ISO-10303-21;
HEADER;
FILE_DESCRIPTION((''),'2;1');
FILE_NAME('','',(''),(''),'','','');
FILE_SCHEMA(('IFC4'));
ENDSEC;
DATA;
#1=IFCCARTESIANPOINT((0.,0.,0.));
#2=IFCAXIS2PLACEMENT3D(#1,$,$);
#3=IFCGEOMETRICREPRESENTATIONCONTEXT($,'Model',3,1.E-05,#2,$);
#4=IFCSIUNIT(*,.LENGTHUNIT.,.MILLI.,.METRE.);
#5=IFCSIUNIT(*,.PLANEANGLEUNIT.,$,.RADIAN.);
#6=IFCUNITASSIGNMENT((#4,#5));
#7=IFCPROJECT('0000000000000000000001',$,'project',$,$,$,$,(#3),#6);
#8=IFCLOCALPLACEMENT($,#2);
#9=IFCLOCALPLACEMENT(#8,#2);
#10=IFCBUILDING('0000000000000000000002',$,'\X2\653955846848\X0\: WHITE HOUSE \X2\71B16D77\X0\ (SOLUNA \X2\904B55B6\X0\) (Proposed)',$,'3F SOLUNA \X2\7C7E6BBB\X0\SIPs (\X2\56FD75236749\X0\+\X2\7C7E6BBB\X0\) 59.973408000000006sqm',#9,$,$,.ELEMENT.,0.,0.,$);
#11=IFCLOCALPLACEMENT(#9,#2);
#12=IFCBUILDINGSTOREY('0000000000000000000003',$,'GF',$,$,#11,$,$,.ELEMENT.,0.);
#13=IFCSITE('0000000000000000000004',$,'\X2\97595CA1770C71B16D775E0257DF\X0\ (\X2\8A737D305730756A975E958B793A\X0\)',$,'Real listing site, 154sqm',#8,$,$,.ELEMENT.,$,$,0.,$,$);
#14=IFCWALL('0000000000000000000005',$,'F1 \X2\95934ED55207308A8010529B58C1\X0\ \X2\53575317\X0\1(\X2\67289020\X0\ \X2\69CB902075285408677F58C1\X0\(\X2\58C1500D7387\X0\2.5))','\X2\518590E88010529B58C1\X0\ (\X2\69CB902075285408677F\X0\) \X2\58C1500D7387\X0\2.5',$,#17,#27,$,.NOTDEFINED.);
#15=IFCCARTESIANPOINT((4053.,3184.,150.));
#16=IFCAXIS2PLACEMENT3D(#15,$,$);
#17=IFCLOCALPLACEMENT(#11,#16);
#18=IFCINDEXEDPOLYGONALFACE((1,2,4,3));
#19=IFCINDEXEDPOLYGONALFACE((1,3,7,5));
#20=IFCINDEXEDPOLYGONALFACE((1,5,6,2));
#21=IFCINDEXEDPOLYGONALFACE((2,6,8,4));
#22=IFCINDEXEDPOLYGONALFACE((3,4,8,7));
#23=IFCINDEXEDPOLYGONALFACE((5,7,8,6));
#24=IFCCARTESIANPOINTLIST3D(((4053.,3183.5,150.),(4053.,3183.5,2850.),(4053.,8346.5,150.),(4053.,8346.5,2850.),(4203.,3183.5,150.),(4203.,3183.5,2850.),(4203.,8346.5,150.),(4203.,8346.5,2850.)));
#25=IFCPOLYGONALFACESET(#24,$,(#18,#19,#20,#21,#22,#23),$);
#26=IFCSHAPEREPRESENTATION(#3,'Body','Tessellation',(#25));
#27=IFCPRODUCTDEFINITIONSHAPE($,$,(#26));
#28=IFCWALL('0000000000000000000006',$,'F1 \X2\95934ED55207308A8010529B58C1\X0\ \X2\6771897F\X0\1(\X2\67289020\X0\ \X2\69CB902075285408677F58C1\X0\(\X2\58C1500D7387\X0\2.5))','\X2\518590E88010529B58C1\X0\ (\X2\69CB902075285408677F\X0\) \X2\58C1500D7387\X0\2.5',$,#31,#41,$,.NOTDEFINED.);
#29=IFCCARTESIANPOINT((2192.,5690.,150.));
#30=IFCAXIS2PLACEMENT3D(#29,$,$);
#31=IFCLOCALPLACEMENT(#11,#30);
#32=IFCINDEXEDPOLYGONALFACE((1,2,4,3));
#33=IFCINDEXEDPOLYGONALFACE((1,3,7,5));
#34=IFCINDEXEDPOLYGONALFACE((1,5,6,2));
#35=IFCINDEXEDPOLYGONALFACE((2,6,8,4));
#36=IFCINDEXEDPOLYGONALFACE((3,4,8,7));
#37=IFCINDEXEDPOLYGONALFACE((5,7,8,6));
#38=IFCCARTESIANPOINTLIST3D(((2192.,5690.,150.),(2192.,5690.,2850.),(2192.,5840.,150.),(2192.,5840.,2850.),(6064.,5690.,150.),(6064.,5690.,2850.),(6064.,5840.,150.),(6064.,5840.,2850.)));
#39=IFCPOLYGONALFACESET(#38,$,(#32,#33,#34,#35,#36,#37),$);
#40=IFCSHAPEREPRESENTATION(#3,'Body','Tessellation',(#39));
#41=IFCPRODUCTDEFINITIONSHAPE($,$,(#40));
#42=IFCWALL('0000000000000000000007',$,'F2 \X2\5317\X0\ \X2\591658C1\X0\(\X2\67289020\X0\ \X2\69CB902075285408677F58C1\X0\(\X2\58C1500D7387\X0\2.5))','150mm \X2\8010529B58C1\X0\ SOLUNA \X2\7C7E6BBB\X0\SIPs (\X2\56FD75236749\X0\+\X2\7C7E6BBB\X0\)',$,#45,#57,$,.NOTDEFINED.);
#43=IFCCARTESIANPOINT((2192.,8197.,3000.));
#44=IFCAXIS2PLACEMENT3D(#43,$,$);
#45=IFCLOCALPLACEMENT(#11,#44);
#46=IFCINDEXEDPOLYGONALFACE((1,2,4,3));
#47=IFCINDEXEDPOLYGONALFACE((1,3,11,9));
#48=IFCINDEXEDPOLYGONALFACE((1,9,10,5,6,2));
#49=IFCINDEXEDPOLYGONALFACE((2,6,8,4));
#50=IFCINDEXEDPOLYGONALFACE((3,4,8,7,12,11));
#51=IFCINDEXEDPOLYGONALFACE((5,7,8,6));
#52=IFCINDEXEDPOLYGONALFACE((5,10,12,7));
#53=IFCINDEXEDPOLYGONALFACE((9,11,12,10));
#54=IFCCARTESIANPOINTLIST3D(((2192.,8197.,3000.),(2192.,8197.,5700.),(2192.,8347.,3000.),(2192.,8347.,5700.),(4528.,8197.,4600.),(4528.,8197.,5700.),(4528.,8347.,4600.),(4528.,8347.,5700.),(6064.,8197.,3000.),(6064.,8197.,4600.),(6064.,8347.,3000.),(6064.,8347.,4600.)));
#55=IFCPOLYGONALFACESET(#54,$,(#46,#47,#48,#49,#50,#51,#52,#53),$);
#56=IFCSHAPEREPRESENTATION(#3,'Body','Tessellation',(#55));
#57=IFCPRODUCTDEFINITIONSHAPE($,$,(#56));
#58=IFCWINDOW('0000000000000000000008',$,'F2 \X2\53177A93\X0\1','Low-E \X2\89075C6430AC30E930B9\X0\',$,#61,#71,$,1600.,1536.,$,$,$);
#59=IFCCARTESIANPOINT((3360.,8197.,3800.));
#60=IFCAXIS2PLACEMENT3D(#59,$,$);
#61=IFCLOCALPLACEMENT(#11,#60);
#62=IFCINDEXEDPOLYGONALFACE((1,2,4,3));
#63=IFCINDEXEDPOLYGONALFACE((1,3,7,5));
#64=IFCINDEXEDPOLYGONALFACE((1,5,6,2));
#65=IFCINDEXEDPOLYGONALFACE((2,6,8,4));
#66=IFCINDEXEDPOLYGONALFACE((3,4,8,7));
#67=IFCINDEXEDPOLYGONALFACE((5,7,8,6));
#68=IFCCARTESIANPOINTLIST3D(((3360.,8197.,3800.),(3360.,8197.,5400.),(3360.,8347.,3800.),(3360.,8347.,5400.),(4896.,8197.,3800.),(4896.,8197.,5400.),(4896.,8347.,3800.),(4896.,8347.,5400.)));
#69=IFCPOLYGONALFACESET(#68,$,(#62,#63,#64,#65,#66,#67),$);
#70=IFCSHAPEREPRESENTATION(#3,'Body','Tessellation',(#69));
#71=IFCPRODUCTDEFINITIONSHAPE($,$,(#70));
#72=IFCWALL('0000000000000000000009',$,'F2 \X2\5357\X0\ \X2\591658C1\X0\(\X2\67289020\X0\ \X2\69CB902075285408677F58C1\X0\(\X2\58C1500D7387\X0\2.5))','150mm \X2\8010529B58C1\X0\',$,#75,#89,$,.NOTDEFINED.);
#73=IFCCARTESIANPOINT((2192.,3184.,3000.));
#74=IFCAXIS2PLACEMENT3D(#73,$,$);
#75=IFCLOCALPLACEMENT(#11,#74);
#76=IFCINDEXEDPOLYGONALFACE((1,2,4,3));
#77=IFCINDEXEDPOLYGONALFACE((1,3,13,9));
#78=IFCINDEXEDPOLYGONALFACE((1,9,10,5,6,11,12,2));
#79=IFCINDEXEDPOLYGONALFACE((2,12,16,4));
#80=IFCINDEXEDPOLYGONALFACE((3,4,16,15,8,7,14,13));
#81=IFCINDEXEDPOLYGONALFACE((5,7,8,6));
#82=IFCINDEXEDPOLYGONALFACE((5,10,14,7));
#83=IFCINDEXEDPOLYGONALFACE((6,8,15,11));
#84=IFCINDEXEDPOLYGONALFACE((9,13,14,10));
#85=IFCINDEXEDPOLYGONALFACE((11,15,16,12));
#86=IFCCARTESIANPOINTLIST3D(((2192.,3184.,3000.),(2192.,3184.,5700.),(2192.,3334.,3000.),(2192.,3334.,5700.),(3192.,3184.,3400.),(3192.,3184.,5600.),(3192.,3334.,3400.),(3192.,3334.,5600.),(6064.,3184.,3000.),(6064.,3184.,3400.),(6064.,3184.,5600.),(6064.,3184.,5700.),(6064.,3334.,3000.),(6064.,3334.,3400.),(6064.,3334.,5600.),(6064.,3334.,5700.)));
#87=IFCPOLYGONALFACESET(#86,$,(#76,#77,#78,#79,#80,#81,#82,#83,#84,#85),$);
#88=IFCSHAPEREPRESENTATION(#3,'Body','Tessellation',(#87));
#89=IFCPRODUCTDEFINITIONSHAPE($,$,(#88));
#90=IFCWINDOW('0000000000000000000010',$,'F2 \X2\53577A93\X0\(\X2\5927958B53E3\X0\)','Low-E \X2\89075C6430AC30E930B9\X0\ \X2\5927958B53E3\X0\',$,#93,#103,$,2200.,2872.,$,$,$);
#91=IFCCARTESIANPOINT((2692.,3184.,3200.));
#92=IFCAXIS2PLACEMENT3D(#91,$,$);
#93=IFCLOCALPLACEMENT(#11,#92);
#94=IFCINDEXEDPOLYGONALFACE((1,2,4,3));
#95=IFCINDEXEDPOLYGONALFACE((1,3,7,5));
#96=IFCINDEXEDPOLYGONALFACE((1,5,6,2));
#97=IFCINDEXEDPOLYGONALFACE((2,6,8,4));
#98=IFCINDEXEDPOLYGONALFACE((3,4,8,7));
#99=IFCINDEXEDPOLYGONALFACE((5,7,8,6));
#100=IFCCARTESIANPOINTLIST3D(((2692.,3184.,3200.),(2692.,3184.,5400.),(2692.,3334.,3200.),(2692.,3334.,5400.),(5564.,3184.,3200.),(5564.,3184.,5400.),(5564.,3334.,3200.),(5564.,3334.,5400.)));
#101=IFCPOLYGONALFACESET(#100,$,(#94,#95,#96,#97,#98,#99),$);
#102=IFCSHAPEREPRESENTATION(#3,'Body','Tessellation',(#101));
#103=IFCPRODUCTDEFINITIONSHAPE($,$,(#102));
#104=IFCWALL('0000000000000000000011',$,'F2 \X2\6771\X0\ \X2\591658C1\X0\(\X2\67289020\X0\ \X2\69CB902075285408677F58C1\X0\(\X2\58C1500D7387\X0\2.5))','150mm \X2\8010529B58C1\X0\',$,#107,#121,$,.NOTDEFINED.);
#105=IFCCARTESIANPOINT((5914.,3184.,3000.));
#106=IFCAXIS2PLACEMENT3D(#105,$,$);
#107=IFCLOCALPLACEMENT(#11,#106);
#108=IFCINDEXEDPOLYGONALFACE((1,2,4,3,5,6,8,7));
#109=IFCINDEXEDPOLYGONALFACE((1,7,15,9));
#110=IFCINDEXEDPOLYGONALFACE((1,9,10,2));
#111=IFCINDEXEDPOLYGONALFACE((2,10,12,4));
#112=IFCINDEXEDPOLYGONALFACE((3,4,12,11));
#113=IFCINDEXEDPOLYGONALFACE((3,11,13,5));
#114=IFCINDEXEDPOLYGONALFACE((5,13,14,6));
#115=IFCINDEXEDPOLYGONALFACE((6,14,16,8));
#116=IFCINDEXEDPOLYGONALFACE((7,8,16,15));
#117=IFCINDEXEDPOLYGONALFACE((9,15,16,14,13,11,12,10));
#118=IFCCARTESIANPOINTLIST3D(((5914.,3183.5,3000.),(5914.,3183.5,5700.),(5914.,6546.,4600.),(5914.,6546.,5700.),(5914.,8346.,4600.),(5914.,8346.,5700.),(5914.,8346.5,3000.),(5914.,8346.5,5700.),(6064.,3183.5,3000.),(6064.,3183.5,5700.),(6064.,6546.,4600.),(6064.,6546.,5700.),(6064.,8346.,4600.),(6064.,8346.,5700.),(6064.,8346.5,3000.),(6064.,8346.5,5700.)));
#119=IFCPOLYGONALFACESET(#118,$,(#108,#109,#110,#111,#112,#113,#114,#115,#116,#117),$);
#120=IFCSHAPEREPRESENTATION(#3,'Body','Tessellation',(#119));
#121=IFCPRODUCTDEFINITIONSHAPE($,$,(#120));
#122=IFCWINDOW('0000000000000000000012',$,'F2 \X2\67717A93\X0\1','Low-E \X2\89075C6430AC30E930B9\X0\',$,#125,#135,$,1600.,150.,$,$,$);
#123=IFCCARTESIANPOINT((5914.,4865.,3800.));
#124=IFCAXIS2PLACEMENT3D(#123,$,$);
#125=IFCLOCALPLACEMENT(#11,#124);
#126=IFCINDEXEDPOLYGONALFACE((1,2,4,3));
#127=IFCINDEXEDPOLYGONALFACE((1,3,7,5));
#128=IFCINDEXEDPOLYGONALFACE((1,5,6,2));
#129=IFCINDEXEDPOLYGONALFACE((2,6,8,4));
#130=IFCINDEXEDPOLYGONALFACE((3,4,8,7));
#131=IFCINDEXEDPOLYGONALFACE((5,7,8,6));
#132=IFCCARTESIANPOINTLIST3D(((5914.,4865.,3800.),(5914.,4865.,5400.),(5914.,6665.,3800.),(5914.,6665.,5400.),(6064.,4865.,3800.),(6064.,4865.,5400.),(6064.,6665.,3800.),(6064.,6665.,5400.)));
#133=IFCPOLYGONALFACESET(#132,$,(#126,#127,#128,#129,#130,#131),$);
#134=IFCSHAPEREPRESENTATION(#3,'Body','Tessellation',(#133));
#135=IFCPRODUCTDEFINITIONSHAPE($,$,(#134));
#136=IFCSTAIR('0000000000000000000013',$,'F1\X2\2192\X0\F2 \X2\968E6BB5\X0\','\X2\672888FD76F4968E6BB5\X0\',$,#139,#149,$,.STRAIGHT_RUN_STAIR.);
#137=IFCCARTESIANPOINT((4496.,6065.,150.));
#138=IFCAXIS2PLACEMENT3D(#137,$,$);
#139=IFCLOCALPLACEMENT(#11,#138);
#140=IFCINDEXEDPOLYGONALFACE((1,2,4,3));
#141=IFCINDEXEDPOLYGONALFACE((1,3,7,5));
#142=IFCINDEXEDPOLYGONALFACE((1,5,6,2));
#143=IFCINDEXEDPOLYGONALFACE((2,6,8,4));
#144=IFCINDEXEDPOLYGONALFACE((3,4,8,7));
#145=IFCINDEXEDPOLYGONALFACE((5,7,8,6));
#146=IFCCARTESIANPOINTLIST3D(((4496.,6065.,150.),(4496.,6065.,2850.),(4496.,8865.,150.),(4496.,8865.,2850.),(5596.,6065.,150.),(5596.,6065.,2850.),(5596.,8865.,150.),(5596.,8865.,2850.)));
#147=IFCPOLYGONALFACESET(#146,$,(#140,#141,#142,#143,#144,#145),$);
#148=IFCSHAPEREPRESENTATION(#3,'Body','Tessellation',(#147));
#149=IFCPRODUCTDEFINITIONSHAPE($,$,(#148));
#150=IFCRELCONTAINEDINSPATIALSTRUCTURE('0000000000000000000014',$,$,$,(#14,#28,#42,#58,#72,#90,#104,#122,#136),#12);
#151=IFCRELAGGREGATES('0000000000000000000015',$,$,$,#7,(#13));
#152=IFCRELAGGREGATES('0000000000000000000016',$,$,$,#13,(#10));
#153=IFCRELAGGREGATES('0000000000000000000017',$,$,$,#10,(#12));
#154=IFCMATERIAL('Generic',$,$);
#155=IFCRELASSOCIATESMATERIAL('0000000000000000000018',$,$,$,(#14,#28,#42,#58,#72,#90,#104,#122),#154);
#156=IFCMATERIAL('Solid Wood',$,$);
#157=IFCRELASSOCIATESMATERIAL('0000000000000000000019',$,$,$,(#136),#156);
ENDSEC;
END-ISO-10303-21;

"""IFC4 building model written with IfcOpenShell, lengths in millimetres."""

from ifc_helpers import new_model, si_unit, frame, frame_2d, origin, place, context, project, spatial, rectangle, extrude, material, element, fill, save


model = new_model("IFC4")

# Units and contexts
model_context = context("Model", 3, precision=1e-05, world=origin())
ifc_project = project(units=[si_unit("LENGTHUNIT", "METRE", prefix="MILLI"), si_unit("PLANEANGLEUNIT", "RADIAN")], contexts=[model_context])

# Site, building, storey
site_placement = place(None, origin())
site = spatial("IfcSite", under=ifc_project, at=site_placement, Name="静岡県熱海市域 (詳細地番非開示)", ObjectType="Real listing site, 154sqm", CompositionType="ELEMENT", RefElevation=0.0)
building_placement = place(site_placement, origin())
building = spatial("IfcBuilding", under=site, at=building_placement, Name="改善案: WHITE HOUSE 熱海 (SOLUNA 運営) (Proposed)", ObjectType="3F SOLUNA 籾殻SIPs (国産杉+籾殻) 59.973408000000006sqm", CompositionType="ELEMENT", ElevationOfRefHeight=0.0, ElevationOfTerrain=0.0)
storey_placement = place(building_placement, origin())
storey = spatial("IfcBuildingStorey", under=building, at=storey_placement, Name="GF", CompositionType="ELEMENT", Elevation=0.0)

# Shared definitions
ifc_material_1 = material(Name="Generic")

# Shared definitions
ifc_material_2 = material(Name="Solid Wood")

# Walls
wall_1_placement = place(storey_placement, frame((4053.0, 3184.0, 150.0)))
element("IfcWall", 1, at=wall_1_placement, inside=storey, material=ifc_material_1, Name="F1 間仕切り耐力壁 南北1(木造 構造用合板壁(壁倍率2.5))", Description="内部耐力壁 (構造用合板) 壁倍率2.5", PredefinedType="NOTDEFINED", context=model_context, shape_type="SweptSolid", body=[
    extrude(rectangle(XDim=150.0, YDim=5163.0, at=frame_2d((75.0, 2581.0))), frame((4053.0, 3184.0, 150.0)), (0.0, 0.0, 1.0), 2700.0),
])
wall_2_placement = place(storey_placement, frame((2192.0, 5690.0, 150.0)))
element("IfcWall", 2, at=wall_2_placement, inside=storey, material=ifc_material_1, Name="F1 間仕切り耐力壁 東西1(木造 構造用合板壁(壁倍率2.5))", Description="内部耐力壁 (構造用合板) 壁倍率2.5", PredefinedType="NOTDEFINED", context=model_context, shape_type="SweptSolid", body=[
    extrude(rectangle(XDim=3872.0, YDim=150.0, at=frame_2d((1936.0, 75.0))), frame((2192.0, 5690.0, 150.0)), (0.0, 0.0, 1.0), 2700.0),
])

# Walls, openings, windows
wall_3_placement = place(storey_placement, frame((2192.0, 8197.0, 3000.0)))
wall_3 = element("IfcWall", 3, at=wall_3_placement, inside=storey, material=ifc_material_1, Name="F2 北 外壁(木造 構造用合板壁(壁倍率2.5))", Description="150mm 耐力壁 SOLUNA 籾殻SIPs (国産杉+籾殻)", PredefinedType="NOTDEFINED", context=model_context, shape_type="SweptSolid", body=[
    extrude(rectangle(XDim=3872.0, YDim=150.0, at=frame_2d((1936.0, 75.0))), frame((2192.0, 8197.0, 3000.0)), (0.0, 0.0, 1.0), 2700.0),
])
opening_1_placement = place(storey_placement, frame((3360.0, 8197.0, 3800.0)))
opening_1 = element("IfcOpeningElement", 4, at=opening_1_placement, cuts=wall_3, PredefinedType="NOTDEFINED", context=model_context, shape_type="SweptSolid", body=[
    extrude(rectangle(XDim=1536.0, YDim=150.0, at=frame_2d((768.0, 75.0))), frame((3360.0, 8197.0, 3800.0)), (0.0, 0.0, 1.0), 1600.0),
])
window_1_placement = place(storey_placement, frame((3360.0, 8197.0, 3800.0)))
window_1 = element("IfcWindow", 5, at=window_1_placement, inside=storey, material=ifc_material_1, Name="F2 北窓1", Description="Low-E 複層ガラス", OverallHeight=1600.0, OverallWidth=1536.0, context=model_context, shape_type="SweptSolid", body=[
    extrude(rectangle(XDim=1536.0, YDim=150.0, at=frame_2d((768.0, 75.0))), frame((3360.0, 8197.0, 3800.0)), (0.0, 0.0, 1.0), 1600.0),
])
fill(opening_1, window_1)
wall_4_placement = place(storey_placement, frame((2192.0, 3184.0, 3000.0)))
wall_4 = element("IfcWall", 6, at=wall_4_placement, inside=storey, material=ifc_material_1, Name="F2 南 外壁(木造 構造用合板壁(壁倍率2.5))", Description="150mm 耐力壁", PredefinedType="NOTDEFINED", context=model_context, shape_type="SweptSolid", body=[
    extrude(rectangle(XDim=3872.0, YDim=150.0, at=frame_2d((1936.0, 75.0))), frame((2192.0, 3184.0, 3000.0)), (0.0, 0.0, 1.0), 2700.0),
])
opening_2_placement = place(storey_placement, frame((2692.0, 3184.0, 3200.0)))
opening_2 = element("IfcOpeningElement", 7, at=opening_2_placement, cuts=wall_4, PredefinedType="NOTDEFINED", context=model_context, shape_type="SweptSolid", body=[
    extrude(rectangle(XDim=2872.0, YDim=150.0, at=frame_2d((1436.0, 75.0))), frame((2692.0, 3184.0, 3200.0)), (0.0, 0.0, 1.0), 2200.0),
])
window_2_placement = place(storey_placement, frame((2692.0, 3184.0, 3200.0)))
window_2 = element("IfcWindow", 8, at=window_2_placement, inside=storey, material=ifc_material_1, Name="F2 南窓(大開口)", Description="Low-E 複層ガラス 大開口", OverallHeight=2200.0, OverallWidth=2872.0, context=model_context, shape_type="SweptSolid", body=[
    extrude(rectangle(XDim=2872.0, YDim=150.0, at=frame_2d((1436.0, 75.0))), frame((2692.0, 3184.0, 3200.0)), (0.0, 0.0, 1.0), 2200.0),
])
fill(opening_2, window_2)
wall_5_placement = place(storey_placement, frame((5914.0, 3184.0, 3000.0)))
wall_5 = element("IfcWall", 9, at=wall_5_placement, inside=storey, material=ifc_material_1, Name="F2 東 外壁(木造 構造用合板壁(壁倍率2.5))", Description="150mm 耐力壁", PredefinedType="NOTDEFINED", context=model_context, shape_type="SweptSolid", body=[
    extrude(rectangle(XDim=150.0, YDim=5163.0, at=frame_2d((75.0, 2581.0))), frame((5914.0, 3184.0, 3000.0)), (0.0, 0.0, 1.0), 2700.0),
])
opening_3_placement = place(storey_placement, frame((5914.0, 4865.0, 3800.0)))
opening_3 = element("IfcOpeningElement", 10, at=opening_3_placement, cuts=wall_5, PredefinedType="NOTDEFINED", context=model_context, shape_type="SweptSolid", body=[
    extrude(rectangle(XDim=150.0, YDim=1800.0, at=frame_2d((75.0, 900.0))), frame((5914.0, 4865.0, 3800.0)), (0.0, 0.0, 1.0), 1600.0),
])
window_3_placement = place(storey_placement, frame((5914.0, 4865.0, 3800.0)))
window_3 = element("IfcWindow", 11, at=window_3_placement, inside=storey, material=ifc_material_1, Name="F2 東窓1", Description="Low-E 複層ガラス", OverallHeight=1600.0, OverallWidth=150.0, context=model_context, shape_type="SweptSolid", body=[
    extrude(rectangle(XDim=150.0, YDim=1800.0, at=frame_2d((75.0, 900.0))), frame((5914.0, 4865.0, 3800.0)), (0.0, 0.0, 1.0), 1600.0),
])
fill(opening_3, window_3)

# Stair
stair_placement = place(storey_placement, frame((4496.0, 6065.0, 150.0)))
element("IfcStair", 12, at=stair_placement, inside=storey, material=ifc_material_2, Name="F1→F2 階段", Description="木製直階段", PredefinedType="STRAIGHT_RUN_STAIR", context=model_context, shape_type="SweptSolid", body=[
    extrude(rectangle(XDim=1100.0, YDim=2800.0, at=frame_2d((550.0, 1400.0))), frame((4496.0, 6065.0, 150.0)), (0.0, 0.0, 1.0), 2700.0),
])

save(model, "model.ifc")
